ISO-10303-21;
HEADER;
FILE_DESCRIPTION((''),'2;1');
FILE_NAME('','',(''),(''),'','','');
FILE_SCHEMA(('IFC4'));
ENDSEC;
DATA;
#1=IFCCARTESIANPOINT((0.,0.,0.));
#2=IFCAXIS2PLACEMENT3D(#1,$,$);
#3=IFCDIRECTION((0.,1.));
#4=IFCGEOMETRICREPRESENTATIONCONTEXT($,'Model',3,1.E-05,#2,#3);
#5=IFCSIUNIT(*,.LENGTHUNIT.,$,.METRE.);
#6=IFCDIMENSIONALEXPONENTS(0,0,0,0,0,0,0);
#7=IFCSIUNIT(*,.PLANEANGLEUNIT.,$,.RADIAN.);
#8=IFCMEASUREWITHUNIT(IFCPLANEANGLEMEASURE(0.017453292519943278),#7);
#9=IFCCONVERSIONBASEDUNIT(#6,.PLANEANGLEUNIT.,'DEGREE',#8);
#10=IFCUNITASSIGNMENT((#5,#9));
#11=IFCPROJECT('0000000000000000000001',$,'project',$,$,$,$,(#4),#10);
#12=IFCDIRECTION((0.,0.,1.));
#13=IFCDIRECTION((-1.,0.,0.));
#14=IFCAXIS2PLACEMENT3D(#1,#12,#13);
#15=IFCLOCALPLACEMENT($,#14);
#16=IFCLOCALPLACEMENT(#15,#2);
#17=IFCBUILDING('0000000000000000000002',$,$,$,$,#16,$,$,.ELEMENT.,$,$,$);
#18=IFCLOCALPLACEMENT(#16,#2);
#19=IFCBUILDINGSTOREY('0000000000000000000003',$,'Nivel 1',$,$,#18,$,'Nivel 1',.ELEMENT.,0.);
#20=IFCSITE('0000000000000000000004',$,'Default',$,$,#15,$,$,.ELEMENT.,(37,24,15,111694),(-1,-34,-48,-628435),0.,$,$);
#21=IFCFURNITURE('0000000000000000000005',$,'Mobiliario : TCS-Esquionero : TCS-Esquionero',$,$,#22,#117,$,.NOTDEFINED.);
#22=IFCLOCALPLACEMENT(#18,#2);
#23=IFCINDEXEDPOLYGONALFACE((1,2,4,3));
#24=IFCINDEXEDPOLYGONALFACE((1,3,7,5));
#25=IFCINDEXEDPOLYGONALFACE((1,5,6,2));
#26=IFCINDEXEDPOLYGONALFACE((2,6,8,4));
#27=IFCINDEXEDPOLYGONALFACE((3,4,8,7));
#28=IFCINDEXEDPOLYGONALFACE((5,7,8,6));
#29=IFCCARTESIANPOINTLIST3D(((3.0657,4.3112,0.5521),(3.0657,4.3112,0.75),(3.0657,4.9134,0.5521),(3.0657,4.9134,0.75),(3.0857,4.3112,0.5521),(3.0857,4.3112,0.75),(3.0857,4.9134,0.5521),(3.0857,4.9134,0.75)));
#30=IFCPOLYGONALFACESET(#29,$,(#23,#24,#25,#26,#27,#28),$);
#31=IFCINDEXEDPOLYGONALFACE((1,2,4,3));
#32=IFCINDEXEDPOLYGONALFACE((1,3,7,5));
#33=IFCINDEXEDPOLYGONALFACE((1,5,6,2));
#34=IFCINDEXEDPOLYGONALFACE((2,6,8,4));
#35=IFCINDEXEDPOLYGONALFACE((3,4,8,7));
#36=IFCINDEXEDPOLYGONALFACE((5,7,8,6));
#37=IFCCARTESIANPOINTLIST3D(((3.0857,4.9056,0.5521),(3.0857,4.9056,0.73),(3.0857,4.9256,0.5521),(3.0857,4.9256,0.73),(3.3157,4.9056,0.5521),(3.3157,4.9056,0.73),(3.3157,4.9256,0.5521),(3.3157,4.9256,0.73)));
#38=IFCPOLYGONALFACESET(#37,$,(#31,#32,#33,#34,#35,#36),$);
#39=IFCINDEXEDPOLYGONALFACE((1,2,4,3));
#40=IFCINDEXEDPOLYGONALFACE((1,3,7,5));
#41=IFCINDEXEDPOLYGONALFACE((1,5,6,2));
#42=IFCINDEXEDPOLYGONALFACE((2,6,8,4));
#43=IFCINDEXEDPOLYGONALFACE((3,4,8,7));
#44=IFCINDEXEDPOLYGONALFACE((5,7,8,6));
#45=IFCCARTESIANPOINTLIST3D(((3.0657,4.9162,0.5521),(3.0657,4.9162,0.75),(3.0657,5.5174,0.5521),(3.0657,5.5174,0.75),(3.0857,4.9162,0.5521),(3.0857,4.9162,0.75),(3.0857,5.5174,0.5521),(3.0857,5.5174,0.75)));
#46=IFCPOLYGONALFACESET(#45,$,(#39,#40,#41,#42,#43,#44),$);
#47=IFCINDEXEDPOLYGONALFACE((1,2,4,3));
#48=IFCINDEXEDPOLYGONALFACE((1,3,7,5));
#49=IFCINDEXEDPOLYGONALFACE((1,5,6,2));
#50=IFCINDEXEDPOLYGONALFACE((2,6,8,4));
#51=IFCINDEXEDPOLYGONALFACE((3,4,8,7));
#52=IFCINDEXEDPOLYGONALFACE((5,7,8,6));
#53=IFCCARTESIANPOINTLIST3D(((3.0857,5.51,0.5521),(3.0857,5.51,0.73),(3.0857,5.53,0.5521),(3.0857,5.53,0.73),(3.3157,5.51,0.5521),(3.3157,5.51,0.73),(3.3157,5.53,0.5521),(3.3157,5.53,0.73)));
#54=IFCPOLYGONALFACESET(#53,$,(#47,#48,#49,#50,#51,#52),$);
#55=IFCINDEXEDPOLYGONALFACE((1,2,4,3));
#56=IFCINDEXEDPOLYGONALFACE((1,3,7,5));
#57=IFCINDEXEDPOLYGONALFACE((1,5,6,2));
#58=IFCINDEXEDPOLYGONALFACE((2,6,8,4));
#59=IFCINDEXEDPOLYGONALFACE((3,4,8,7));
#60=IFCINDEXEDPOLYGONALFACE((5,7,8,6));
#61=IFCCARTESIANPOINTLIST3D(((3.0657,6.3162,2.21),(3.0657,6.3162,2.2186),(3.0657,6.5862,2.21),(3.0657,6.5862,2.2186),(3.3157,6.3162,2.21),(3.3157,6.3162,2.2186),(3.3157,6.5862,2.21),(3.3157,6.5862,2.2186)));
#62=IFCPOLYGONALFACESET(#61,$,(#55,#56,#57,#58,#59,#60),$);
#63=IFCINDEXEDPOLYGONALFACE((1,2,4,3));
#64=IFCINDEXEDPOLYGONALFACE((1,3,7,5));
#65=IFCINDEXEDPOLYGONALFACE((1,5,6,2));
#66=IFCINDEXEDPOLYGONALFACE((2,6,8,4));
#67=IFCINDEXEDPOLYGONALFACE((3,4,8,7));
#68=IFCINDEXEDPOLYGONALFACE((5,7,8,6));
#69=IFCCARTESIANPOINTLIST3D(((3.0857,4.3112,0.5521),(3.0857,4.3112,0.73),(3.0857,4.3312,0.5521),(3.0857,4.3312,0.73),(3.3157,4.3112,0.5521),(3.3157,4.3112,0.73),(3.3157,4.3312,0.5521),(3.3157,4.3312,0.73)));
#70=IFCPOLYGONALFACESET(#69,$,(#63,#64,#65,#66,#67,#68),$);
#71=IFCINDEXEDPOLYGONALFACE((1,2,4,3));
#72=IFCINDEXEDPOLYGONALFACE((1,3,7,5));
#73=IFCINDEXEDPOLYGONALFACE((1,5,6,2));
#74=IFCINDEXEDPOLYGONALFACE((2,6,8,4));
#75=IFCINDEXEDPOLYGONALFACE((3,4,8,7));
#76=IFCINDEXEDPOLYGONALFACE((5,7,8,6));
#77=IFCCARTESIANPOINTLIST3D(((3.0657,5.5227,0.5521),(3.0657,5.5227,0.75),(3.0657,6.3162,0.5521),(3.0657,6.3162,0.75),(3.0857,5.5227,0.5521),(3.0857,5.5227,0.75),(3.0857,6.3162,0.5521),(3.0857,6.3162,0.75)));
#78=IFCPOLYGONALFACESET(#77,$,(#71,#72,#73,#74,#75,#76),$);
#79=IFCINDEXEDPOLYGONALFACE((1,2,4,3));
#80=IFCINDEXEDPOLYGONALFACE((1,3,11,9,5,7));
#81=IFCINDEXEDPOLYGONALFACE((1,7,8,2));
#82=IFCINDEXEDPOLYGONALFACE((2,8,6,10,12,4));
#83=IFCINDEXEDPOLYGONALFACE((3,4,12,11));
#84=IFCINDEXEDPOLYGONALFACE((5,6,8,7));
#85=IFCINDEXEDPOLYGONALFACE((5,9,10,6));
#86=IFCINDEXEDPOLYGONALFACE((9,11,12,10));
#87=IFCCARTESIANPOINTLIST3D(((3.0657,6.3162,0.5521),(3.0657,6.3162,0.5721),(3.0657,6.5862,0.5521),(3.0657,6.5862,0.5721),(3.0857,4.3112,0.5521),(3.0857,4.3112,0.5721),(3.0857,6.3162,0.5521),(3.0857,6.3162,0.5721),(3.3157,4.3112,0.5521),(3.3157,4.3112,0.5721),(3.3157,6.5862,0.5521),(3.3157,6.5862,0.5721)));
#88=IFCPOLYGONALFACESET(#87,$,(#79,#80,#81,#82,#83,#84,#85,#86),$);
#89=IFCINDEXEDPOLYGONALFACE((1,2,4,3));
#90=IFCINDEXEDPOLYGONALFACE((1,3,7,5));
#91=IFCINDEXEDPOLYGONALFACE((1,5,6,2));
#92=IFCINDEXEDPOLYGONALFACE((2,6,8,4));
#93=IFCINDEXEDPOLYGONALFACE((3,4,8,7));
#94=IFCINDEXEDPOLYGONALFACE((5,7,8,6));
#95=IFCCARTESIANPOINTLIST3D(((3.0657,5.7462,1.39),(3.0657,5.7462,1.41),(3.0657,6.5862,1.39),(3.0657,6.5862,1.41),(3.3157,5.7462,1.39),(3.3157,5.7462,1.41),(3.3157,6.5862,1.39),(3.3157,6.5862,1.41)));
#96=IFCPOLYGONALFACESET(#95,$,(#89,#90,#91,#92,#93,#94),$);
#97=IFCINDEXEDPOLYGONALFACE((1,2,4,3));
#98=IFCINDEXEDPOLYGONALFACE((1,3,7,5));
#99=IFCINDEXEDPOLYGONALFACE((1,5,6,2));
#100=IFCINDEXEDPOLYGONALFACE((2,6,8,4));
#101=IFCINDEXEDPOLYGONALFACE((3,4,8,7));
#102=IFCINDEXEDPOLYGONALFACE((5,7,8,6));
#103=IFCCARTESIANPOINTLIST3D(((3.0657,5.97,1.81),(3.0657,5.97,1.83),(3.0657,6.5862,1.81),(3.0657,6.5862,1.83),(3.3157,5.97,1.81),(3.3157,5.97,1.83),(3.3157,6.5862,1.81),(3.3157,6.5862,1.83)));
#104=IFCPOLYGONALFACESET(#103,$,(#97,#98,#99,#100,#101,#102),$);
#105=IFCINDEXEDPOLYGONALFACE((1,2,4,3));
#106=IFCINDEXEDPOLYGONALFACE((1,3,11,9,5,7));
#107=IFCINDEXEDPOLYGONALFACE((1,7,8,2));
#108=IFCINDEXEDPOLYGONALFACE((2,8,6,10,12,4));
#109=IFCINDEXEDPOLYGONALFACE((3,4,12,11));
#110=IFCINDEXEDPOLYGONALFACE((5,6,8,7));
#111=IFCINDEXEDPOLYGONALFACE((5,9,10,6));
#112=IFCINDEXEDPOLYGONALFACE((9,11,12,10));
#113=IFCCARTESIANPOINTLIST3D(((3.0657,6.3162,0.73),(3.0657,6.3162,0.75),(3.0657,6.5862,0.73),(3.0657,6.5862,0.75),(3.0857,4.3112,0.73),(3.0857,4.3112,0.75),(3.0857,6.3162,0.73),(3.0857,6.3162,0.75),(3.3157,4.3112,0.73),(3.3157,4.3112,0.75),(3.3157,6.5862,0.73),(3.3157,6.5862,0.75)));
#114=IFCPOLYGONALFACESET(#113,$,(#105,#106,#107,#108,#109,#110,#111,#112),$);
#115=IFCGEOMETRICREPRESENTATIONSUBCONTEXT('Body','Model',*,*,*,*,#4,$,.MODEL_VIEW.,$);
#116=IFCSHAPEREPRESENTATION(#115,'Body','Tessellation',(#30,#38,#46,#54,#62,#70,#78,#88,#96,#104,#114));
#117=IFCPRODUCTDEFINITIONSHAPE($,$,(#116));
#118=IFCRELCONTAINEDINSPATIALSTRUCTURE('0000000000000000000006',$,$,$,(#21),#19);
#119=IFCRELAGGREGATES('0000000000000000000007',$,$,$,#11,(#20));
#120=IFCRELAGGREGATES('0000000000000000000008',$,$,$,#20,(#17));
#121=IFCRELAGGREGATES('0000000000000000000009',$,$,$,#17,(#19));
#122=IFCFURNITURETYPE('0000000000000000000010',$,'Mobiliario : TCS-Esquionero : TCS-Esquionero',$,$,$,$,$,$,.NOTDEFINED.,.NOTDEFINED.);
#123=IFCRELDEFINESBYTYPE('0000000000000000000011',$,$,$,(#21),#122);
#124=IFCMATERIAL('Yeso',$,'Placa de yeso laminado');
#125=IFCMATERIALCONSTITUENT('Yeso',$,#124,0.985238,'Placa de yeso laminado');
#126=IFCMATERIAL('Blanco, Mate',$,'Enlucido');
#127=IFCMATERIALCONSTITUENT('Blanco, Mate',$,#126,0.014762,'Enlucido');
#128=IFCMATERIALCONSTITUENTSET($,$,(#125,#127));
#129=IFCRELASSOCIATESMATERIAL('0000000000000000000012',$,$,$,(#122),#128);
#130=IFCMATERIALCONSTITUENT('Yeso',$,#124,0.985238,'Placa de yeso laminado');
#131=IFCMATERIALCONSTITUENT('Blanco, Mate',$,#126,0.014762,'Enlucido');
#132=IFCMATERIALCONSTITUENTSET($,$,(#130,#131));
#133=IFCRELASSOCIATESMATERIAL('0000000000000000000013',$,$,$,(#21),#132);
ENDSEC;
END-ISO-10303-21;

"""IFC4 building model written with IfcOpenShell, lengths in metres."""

from ifc_helpers import new_model, entity, si_unit, converted_unit, direction, frame, origin, place, context, subcontext, project, spatial, indexed_curve, outline, extrude, source, transform, mapped, material, constituent, constituent_set, type_object, type_shapes, element, save


model = new_model("IFC4")

# Units and contexts
model_context = context("Model", 3, precision=1e-05, world=origin(), true_north=direction((0.0, 1.0)))
body_context = subcontext(model_context, "Body", "Model", "MODEL_VIEW")
ifc_project = project(units=[si_unit("LENGTHUNIT", "METRE"), converted_unit("PLANEANGLEUNIT", "DEGREE", entity("IfcPlaneAngleMeasure", 0.017453292519943278), si_unit("PLANEANGLEUNIT", "RADIAN"), dimensions=[0, 0, 0, 0, 0, 0, 0])], contexts=[model_context])

# Site, building, storey
site_placement = place(None, frame((0.0, 0.0, 0.0), z_axis=(0.0, 0.0, 1.0), x_axis=(-1.0, 0.0, 0.0)))
site = spatial("IfcSite", under=ifc_project, at=site_placement, Name="Default", CompositionType="ELEMENT", RefLatitude=(37, 24, 15, 111694), RefLongitude=(-1, -34, -48, -628435), RefElevation=0.0)
building_placement = place(site_placement, origin())
building = spatial("IfcBuilding", under=site, at=building_placement, CompositionType="ELEMENT")
storey_placement = place(building_placement, origin())
storey = spatial("IfcBuildingStorey", under=building, at=storey_placement, Name="Nivel 1", LongName="Nivel 1", CompositionType="ELEMENT", Elevation=0.0)

# Furniture
ifc_material_1 = material(Name="Yeso", Category="Placa de yeso laminado")
ifc_constituent_1 = constituent(ifc_material_1, Name="Yeso", Category="Placa de yeso laminado", fraction=0.985238)
ifc_material_2 = material(Name="Blanco, Mate", Category="Enlucido")
ifc_constituent_2 = constituent(ifc_material_2, Name="Blanco, Mate", Category="Enlucido", fraction=0.014762)
ifc_constituent_set_1 = constituent_set(constituents=[ifc_constituent_1, ifc_constituent_2])
ifc_constituent_3 = constituent(ifc_material_1, Name="Yeso", Category="Placa de yeso laminado", fraction=0.985238)
ifc_constituent_4 = constituent(ifc_material_2, Name="Blanco, Mate", Category="Enlucido", fraction=0.014762)
ifc_constituent_set_2 = constituent_set(constituents=[ifc_constituent_3, ifc_constituent_4])
furniture_type_1 = type_object("IfcFurnitureType", Name="Mobiliario : TCS-Esquionero : TCS-Esquionero", AssemblyPlace="NOTDEFINED", PredefinedType="NOTDEFINED", material=ifc_constituent_set_2)
shared_shape_1 = source(origin(), body_context, "Body", "SweptSolid", [
    extrude(outline(indexed_curve([(-0.01, -0.3011), (0.01, -0.3011), (0.01, 0.3011), (-0.01, 0.3011), (-0.01, -0.3011)], self_intersect=False)), frame((3.0757, 4.6123, 0.5521)), (0.0, 0.0, 1.0), 0.1979),
    extrude(outline(indexed_curve([(-0.01, -0.115), (0.01, -0.115), (0.01, 0.115), (-0.01, 0.115), (-0.01, -0.115)], self_intersect=False)), frame((3.2007, 4.9156, 0.5521), z_axis=(0.0, 0.0, 1.0), x_axis=(0.0, -1.0, 0.0)), (0.0, 0.0, 1.0), 0.1779),
    extrude(outline(indexed_curve([(-0.01, -0.3006), (0.01, -0.3006), (0.01, 0.3006), (-0.01, 0.3006), (-0.01, -0.3006)], self_intersect=False)), frame((3.0757, 5.2168, 0.5521)), (0.0, 0.0, 1.0), 0.1979),
    extrude(outline(indexed_curve([(-0.01, -0.115), (0.01, -0.115), (0.01, 0.115), (-0.01, 0.115), (-0.01, -0.115)], self_intersect=False)), frame((3.2007, 5.52, 0.5521), z_axis=(0.0, 0.0, 1.0), x_axis=(0.0, -1.0, 0.0)), (0.0, 0.0, 1.0), 0.1779),
    extrude(outline(indexed_curve([(-0.125, -0.135), (0.125, -0.135), (0.125, 0.135), (-0.125, 0.135), (-0.125, -0.135)], self_intersect=False)), frame((3.1907, 6.4512, 2.21), z_axis=(0.0, 0.0, 1.0), x_axis=(-1.0, 0.0, 0.0)), (0.0, 0.0, 1.0), 0.0086),
    extrude(outline(indexed_curve([(-0.01, -0.115), (0.01, -0.115), (0.01, 0.115), (-0.01, 0.115), (-0.01, -0.115)], self_intersect=False)), frame((3.2007, 4.3212, 0.5521), z_axis=(0.0, 0.0, 1.0), x_axis=(0.0, -1.0, 0.0)), (0.0, 0.0, 1.0), 0.1779),
    extrude(outline(indexed_curve([(-0.01, -0.3968), (0.01, -0.3968), (0.01, 0.3968), (-0.01, 0.3968), (-0.01, -0.3968)], self_intersect=False)), frame((3.0757, 5.9195, 0.5521)), (0.0, 0.0, 1.0), 0.1979),
    extrude(outline(indexed_curve([(-0.16, -0.8483), (0.09, -0.8483), (0.09, -0.5783), (0.07, -0.5783), (0.07, 1.4267), (-0.16, 1.4267), (-0.16, -0.8483)], self_intersect=False)), frame((3.1557, 5.7379, 0.5521), z_axis=(0.0, 0.0, 1.0), x_axis=(-1.0, 0.0, 0.0)), (0.0, 0.0, 1.0), 0.02),
    extrude(outline(indexed_curve([(-0.125, -0.42), (0.125, -0.42), (0.125, 0.42), (-0.125, 0.42), (-0.125, -0.42)], self_intersect=False)), frame((3.1907, 6.1662, 1.39), z_axis=(0.0, 0.0, 1.0), x_axis=(-1.0, 0.0, 0.0)), (0.0, 0.0, 1.0), 0.02),
    extrude(outline(indexed_curve([(-0.125, -0.3081), (0.125, -0.3081), (0.125, 0.3081), (-0.125, 0.3081), (-0.125, -0.3081)], self_intersect=False)), frame((3.1907, 6.2781, 1.81), z_axis=(0.0, 0.0, 1.0), x_axis=(-1.0, 0.0, 0.0)), (0.0, 0.0, 1.0), 0.02),
    extrude(outline(indexed_curve([(-0.16, -0.8483), (0.09, -0.8483), (0.09, -0.5783), (0.07, -0.5783), (0.07, 1.4267), (-0.16, 1.4267), (-0.16, -0.8483)], self_intersect=False)), frame((3.1557, 5.7379, 0.73), z_axis=(0.0, 0.0, 1.0), x_axis=(-1.0, 0.0, 0.0)), (0.0, 0.0, 1.0), 0.02),
])
type_shapes(furniture_type_1, [shared_shape_1])
furniture_1_placement = place(storey_placement, origin())
element("IfcFurniture", 1, at=furniture_1_placement, inside=storey, type_object=furniture_type_1, material=ifc_constituent_set_1, Name="Mobiliario : TCS-Esquionero : TCS-Esquionero", PredefinedType="NOTDEFINED", context=body_context, shape_type="MappedRepresentation", body=[
    mapped(shared_shape_1, transform((0.0, 0.0, 0.0), scale=1.0)),
])

save(model, "model.ifc")
